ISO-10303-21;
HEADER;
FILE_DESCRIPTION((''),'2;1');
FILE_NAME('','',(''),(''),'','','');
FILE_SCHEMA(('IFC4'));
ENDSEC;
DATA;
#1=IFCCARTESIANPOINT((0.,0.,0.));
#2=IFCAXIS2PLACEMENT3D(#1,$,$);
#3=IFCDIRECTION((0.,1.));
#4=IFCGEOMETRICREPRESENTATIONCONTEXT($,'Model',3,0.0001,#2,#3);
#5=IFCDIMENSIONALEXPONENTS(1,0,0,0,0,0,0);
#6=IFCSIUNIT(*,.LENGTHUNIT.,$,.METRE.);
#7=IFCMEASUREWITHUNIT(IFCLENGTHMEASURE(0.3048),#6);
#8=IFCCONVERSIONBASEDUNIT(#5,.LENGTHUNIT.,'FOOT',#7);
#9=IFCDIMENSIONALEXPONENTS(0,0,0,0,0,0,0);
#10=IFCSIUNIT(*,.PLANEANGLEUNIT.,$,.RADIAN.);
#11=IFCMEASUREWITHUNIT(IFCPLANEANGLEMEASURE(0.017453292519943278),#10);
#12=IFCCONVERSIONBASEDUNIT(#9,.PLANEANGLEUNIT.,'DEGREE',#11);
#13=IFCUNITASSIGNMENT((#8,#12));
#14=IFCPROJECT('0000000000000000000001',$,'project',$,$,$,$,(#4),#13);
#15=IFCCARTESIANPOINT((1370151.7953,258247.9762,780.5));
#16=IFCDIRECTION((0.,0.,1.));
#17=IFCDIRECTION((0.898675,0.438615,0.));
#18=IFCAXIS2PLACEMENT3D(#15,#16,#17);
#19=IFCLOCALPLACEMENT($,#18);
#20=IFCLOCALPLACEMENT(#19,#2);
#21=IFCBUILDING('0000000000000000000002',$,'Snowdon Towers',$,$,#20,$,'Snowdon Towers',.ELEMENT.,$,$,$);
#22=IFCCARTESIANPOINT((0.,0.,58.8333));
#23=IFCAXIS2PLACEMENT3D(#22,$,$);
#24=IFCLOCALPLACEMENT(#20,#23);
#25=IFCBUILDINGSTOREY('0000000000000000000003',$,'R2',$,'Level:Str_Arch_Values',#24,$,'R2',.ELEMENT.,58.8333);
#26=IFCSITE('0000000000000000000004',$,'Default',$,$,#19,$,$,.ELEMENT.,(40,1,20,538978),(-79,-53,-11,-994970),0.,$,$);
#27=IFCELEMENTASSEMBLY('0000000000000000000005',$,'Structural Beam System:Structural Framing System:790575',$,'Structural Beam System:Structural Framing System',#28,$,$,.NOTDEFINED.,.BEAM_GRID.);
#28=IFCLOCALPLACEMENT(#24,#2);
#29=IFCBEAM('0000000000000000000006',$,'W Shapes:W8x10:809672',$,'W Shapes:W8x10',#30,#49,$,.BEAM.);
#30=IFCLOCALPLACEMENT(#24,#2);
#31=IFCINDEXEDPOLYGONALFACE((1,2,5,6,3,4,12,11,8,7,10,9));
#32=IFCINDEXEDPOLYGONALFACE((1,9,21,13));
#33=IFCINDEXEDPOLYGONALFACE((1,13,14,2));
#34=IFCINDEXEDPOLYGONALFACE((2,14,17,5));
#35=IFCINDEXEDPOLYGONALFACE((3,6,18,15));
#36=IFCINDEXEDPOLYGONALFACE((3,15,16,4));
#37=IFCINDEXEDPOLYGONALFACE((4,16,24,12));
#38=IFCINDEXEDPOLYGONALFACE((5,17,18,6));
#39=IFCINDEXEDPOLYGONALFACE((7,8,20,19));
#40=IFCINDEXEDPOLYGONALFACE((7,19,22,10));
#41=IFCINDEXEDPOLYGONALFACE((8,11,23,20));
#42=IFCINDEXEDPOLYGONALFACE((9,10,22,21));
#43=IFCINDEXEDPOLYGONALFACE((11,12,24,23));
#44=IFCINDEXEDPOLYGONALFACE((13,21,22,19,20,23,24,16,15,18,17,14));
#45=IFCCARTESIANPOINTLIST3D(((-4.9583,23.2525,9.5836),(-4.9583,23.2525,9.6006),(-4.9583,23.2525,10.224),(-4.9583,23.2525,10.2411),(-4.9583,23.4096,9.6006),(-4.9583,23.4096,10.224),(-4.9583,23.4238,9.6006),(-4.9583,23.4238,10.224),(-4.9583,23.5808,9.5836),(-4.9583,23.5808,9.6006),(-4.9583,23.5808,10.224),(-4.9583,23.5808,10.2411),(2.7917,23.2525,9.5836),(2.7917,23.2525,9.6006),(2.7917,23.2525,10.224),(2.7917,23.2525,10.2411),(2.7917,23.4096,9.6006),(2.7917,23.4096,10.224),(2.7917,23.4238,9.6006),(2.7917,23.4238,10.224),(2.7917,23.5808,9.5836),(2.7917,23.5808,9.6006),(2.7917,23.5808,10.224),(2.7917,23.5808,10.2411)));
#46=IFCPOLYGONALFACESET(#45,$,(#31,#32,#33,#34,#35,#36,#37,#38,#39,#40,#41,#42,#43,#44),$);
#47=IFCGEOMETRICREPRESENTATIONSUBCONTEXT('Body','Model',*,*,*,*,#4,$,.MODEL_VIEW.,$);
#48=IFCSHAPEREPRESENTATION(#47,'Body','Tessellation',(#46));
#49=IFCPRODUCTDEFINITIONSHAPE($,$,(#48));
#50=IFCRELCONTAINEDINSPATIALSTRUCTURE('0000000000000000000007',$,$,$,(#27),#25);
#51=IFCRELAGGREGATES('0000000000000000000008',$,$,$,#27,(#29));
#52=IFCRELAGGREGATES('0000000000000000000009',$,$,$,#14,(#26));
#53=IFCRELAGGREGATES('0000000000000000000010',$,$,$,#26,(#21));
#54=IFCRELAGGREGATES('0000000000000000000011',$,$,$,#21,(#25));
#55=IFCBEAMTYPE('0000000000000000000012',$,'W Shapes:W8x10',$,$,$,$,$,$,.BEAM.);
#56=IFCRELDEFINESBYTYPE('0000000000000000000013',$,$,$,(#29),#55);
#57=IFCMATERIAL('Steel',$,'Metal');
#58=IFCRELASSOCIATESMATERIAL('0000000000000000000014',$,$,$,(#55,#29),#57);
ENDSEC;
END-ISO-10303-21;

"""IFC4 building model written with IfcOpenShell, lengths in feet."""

from ifc_helpers import new_model, entity, si_unit, converted_unit, direction, frame, origin, place, context, subcontext, project, spatial, indexed_curve, outline, extrude, source, transform, mapped, material, type_object, type_shapes, element, aggregate, save


model = new_model("IFC4")

# Units and contexts
model_context = context("Model", 3, precision=0.0001, world=origin(), true_north=direction((0.0, 1.0)))
body_context = subcontext(model_context, "Body", "Model", "MODEL_VIEW")
ifc_project = project(units=[converted_unit("LENGTHUNIT", "FOOT", entity("IfcLengthMeasure", 0.3048), si_unit("LENGTHUNIT", "METRE"), dimensions=[1, 0, 0, 0, 0, 0, 0]), converted_unit("PLANEANGLEUNIT", "DEGREE", entity("IfcPlaneAngleMeasure", 0.017453292519943278), si_unit("PLANEANGLEUNIT", "RADIAN"), dimensions=[0, 0, 0, 0, 0, 0, 0])], contexts=[model_context])

# Site, building, storey
site_placement = place(None, frame((1370151.7953, 258247.9762, 780.5), z_axis=(0.0, 0.0, 1.0), x_axis=(0.898675, 0.438615, 0.0)))
site = spatial("IfcSite", under=ifc_project, at=site_placement, Name="Default", CompositionType="ELEMENT", RefLatitude=(40, 1, 20, 538978), RefLongitude=(-79, -53, -11, -994970), RefElevation=0.0)
building_placement = place(site_placement, origin())
building = spatial("IfcBuilding", under=site, at=building_placement, Name="Snowdon Towers", LongName="Snowdon Towers", CompositionType="ELEMENT")
storey_placement = place(building_placement, frame((0.0, 0.0, 58.8333)))
storey = spatial("IfcBuildingStorey", under=building, at=storey_placement, Name="R2", ObjectType="Level:Str_Arch_Values", LongName="R2", CompositionType="ELEMENT", Elevation=58.8333)

# Shared definitions
ifc_material_1 = material(Name="Steel", Category="Metal")

# Element assembly, beam
beam_type_1 = type_object("IfcBeamType", Name="W Shapes:W8x10", PredefinedType="BEAM", material=ifc_material_1)
shared_shape_1 = source(origin(), body_context, "Body", "SweptSolid", [
    extrude(outline(indexed_curve([(-0.1642, -0.3117), (-0.1642, -0.3288), (0.1642, -0.3288), (0.1642, -0.3117), (0.0071, -0.3117), (0.0071, 0.3117), (0.1642, 0.3117), (0.1642, 0.3287), (-0.1642, 0.3287), (-0.1642, 0.3117), (-0.0071, 0.3117), (-0.0071, -0.3117), (-0.1642, -0.3117)], self_intersect=False)), frame((-3.875, 0.0, 0.0), z_axis=(-1.0, 0.0, 0.0), x_axis=(0.0, -1.0, 0.0)), (0.0, 0.0, -1.0), 7.75),
])
type_shapes(beam_type_1, [shared_shape_1])
assembly_1_placement = place(storey_placement, origin())
assembly_1 = element("IfcElementAssembly", 1, at=assembly_1_placement, inside=storey, Name="Structural Beam System:Structural Framing System:790575", ObjectType="Structural Beam System:Structural Framing System", AssemblyPlace="NOTDEFINED", PredefinedType="BEAM_GRID")
beam_1_placement = place(assembly_1_placement, frame((-1.0833, 23.4167, 9.9123), z_axis=(0.0, 0.0, 1.0), x_axis=(-1.0, 0.0, 0.0)))
beam_1 = element("IfcBeam", 2, at=beam_1_placement, type_object=beam_type_1, material=ifc_material_1, Name="W Shapes:W8x10:809672", ObjectType="W Shapes:W8x10", PredefinedType="BEAM", context=body_context, shape_type="MappedRepresentation", body=[
    mapped(shared_shape_1, transform((0.0, 0.0, 0.0), scale=1.0)),
])
aggregate(assembly_1, [beam_1])

save(model, "model.ifc")
